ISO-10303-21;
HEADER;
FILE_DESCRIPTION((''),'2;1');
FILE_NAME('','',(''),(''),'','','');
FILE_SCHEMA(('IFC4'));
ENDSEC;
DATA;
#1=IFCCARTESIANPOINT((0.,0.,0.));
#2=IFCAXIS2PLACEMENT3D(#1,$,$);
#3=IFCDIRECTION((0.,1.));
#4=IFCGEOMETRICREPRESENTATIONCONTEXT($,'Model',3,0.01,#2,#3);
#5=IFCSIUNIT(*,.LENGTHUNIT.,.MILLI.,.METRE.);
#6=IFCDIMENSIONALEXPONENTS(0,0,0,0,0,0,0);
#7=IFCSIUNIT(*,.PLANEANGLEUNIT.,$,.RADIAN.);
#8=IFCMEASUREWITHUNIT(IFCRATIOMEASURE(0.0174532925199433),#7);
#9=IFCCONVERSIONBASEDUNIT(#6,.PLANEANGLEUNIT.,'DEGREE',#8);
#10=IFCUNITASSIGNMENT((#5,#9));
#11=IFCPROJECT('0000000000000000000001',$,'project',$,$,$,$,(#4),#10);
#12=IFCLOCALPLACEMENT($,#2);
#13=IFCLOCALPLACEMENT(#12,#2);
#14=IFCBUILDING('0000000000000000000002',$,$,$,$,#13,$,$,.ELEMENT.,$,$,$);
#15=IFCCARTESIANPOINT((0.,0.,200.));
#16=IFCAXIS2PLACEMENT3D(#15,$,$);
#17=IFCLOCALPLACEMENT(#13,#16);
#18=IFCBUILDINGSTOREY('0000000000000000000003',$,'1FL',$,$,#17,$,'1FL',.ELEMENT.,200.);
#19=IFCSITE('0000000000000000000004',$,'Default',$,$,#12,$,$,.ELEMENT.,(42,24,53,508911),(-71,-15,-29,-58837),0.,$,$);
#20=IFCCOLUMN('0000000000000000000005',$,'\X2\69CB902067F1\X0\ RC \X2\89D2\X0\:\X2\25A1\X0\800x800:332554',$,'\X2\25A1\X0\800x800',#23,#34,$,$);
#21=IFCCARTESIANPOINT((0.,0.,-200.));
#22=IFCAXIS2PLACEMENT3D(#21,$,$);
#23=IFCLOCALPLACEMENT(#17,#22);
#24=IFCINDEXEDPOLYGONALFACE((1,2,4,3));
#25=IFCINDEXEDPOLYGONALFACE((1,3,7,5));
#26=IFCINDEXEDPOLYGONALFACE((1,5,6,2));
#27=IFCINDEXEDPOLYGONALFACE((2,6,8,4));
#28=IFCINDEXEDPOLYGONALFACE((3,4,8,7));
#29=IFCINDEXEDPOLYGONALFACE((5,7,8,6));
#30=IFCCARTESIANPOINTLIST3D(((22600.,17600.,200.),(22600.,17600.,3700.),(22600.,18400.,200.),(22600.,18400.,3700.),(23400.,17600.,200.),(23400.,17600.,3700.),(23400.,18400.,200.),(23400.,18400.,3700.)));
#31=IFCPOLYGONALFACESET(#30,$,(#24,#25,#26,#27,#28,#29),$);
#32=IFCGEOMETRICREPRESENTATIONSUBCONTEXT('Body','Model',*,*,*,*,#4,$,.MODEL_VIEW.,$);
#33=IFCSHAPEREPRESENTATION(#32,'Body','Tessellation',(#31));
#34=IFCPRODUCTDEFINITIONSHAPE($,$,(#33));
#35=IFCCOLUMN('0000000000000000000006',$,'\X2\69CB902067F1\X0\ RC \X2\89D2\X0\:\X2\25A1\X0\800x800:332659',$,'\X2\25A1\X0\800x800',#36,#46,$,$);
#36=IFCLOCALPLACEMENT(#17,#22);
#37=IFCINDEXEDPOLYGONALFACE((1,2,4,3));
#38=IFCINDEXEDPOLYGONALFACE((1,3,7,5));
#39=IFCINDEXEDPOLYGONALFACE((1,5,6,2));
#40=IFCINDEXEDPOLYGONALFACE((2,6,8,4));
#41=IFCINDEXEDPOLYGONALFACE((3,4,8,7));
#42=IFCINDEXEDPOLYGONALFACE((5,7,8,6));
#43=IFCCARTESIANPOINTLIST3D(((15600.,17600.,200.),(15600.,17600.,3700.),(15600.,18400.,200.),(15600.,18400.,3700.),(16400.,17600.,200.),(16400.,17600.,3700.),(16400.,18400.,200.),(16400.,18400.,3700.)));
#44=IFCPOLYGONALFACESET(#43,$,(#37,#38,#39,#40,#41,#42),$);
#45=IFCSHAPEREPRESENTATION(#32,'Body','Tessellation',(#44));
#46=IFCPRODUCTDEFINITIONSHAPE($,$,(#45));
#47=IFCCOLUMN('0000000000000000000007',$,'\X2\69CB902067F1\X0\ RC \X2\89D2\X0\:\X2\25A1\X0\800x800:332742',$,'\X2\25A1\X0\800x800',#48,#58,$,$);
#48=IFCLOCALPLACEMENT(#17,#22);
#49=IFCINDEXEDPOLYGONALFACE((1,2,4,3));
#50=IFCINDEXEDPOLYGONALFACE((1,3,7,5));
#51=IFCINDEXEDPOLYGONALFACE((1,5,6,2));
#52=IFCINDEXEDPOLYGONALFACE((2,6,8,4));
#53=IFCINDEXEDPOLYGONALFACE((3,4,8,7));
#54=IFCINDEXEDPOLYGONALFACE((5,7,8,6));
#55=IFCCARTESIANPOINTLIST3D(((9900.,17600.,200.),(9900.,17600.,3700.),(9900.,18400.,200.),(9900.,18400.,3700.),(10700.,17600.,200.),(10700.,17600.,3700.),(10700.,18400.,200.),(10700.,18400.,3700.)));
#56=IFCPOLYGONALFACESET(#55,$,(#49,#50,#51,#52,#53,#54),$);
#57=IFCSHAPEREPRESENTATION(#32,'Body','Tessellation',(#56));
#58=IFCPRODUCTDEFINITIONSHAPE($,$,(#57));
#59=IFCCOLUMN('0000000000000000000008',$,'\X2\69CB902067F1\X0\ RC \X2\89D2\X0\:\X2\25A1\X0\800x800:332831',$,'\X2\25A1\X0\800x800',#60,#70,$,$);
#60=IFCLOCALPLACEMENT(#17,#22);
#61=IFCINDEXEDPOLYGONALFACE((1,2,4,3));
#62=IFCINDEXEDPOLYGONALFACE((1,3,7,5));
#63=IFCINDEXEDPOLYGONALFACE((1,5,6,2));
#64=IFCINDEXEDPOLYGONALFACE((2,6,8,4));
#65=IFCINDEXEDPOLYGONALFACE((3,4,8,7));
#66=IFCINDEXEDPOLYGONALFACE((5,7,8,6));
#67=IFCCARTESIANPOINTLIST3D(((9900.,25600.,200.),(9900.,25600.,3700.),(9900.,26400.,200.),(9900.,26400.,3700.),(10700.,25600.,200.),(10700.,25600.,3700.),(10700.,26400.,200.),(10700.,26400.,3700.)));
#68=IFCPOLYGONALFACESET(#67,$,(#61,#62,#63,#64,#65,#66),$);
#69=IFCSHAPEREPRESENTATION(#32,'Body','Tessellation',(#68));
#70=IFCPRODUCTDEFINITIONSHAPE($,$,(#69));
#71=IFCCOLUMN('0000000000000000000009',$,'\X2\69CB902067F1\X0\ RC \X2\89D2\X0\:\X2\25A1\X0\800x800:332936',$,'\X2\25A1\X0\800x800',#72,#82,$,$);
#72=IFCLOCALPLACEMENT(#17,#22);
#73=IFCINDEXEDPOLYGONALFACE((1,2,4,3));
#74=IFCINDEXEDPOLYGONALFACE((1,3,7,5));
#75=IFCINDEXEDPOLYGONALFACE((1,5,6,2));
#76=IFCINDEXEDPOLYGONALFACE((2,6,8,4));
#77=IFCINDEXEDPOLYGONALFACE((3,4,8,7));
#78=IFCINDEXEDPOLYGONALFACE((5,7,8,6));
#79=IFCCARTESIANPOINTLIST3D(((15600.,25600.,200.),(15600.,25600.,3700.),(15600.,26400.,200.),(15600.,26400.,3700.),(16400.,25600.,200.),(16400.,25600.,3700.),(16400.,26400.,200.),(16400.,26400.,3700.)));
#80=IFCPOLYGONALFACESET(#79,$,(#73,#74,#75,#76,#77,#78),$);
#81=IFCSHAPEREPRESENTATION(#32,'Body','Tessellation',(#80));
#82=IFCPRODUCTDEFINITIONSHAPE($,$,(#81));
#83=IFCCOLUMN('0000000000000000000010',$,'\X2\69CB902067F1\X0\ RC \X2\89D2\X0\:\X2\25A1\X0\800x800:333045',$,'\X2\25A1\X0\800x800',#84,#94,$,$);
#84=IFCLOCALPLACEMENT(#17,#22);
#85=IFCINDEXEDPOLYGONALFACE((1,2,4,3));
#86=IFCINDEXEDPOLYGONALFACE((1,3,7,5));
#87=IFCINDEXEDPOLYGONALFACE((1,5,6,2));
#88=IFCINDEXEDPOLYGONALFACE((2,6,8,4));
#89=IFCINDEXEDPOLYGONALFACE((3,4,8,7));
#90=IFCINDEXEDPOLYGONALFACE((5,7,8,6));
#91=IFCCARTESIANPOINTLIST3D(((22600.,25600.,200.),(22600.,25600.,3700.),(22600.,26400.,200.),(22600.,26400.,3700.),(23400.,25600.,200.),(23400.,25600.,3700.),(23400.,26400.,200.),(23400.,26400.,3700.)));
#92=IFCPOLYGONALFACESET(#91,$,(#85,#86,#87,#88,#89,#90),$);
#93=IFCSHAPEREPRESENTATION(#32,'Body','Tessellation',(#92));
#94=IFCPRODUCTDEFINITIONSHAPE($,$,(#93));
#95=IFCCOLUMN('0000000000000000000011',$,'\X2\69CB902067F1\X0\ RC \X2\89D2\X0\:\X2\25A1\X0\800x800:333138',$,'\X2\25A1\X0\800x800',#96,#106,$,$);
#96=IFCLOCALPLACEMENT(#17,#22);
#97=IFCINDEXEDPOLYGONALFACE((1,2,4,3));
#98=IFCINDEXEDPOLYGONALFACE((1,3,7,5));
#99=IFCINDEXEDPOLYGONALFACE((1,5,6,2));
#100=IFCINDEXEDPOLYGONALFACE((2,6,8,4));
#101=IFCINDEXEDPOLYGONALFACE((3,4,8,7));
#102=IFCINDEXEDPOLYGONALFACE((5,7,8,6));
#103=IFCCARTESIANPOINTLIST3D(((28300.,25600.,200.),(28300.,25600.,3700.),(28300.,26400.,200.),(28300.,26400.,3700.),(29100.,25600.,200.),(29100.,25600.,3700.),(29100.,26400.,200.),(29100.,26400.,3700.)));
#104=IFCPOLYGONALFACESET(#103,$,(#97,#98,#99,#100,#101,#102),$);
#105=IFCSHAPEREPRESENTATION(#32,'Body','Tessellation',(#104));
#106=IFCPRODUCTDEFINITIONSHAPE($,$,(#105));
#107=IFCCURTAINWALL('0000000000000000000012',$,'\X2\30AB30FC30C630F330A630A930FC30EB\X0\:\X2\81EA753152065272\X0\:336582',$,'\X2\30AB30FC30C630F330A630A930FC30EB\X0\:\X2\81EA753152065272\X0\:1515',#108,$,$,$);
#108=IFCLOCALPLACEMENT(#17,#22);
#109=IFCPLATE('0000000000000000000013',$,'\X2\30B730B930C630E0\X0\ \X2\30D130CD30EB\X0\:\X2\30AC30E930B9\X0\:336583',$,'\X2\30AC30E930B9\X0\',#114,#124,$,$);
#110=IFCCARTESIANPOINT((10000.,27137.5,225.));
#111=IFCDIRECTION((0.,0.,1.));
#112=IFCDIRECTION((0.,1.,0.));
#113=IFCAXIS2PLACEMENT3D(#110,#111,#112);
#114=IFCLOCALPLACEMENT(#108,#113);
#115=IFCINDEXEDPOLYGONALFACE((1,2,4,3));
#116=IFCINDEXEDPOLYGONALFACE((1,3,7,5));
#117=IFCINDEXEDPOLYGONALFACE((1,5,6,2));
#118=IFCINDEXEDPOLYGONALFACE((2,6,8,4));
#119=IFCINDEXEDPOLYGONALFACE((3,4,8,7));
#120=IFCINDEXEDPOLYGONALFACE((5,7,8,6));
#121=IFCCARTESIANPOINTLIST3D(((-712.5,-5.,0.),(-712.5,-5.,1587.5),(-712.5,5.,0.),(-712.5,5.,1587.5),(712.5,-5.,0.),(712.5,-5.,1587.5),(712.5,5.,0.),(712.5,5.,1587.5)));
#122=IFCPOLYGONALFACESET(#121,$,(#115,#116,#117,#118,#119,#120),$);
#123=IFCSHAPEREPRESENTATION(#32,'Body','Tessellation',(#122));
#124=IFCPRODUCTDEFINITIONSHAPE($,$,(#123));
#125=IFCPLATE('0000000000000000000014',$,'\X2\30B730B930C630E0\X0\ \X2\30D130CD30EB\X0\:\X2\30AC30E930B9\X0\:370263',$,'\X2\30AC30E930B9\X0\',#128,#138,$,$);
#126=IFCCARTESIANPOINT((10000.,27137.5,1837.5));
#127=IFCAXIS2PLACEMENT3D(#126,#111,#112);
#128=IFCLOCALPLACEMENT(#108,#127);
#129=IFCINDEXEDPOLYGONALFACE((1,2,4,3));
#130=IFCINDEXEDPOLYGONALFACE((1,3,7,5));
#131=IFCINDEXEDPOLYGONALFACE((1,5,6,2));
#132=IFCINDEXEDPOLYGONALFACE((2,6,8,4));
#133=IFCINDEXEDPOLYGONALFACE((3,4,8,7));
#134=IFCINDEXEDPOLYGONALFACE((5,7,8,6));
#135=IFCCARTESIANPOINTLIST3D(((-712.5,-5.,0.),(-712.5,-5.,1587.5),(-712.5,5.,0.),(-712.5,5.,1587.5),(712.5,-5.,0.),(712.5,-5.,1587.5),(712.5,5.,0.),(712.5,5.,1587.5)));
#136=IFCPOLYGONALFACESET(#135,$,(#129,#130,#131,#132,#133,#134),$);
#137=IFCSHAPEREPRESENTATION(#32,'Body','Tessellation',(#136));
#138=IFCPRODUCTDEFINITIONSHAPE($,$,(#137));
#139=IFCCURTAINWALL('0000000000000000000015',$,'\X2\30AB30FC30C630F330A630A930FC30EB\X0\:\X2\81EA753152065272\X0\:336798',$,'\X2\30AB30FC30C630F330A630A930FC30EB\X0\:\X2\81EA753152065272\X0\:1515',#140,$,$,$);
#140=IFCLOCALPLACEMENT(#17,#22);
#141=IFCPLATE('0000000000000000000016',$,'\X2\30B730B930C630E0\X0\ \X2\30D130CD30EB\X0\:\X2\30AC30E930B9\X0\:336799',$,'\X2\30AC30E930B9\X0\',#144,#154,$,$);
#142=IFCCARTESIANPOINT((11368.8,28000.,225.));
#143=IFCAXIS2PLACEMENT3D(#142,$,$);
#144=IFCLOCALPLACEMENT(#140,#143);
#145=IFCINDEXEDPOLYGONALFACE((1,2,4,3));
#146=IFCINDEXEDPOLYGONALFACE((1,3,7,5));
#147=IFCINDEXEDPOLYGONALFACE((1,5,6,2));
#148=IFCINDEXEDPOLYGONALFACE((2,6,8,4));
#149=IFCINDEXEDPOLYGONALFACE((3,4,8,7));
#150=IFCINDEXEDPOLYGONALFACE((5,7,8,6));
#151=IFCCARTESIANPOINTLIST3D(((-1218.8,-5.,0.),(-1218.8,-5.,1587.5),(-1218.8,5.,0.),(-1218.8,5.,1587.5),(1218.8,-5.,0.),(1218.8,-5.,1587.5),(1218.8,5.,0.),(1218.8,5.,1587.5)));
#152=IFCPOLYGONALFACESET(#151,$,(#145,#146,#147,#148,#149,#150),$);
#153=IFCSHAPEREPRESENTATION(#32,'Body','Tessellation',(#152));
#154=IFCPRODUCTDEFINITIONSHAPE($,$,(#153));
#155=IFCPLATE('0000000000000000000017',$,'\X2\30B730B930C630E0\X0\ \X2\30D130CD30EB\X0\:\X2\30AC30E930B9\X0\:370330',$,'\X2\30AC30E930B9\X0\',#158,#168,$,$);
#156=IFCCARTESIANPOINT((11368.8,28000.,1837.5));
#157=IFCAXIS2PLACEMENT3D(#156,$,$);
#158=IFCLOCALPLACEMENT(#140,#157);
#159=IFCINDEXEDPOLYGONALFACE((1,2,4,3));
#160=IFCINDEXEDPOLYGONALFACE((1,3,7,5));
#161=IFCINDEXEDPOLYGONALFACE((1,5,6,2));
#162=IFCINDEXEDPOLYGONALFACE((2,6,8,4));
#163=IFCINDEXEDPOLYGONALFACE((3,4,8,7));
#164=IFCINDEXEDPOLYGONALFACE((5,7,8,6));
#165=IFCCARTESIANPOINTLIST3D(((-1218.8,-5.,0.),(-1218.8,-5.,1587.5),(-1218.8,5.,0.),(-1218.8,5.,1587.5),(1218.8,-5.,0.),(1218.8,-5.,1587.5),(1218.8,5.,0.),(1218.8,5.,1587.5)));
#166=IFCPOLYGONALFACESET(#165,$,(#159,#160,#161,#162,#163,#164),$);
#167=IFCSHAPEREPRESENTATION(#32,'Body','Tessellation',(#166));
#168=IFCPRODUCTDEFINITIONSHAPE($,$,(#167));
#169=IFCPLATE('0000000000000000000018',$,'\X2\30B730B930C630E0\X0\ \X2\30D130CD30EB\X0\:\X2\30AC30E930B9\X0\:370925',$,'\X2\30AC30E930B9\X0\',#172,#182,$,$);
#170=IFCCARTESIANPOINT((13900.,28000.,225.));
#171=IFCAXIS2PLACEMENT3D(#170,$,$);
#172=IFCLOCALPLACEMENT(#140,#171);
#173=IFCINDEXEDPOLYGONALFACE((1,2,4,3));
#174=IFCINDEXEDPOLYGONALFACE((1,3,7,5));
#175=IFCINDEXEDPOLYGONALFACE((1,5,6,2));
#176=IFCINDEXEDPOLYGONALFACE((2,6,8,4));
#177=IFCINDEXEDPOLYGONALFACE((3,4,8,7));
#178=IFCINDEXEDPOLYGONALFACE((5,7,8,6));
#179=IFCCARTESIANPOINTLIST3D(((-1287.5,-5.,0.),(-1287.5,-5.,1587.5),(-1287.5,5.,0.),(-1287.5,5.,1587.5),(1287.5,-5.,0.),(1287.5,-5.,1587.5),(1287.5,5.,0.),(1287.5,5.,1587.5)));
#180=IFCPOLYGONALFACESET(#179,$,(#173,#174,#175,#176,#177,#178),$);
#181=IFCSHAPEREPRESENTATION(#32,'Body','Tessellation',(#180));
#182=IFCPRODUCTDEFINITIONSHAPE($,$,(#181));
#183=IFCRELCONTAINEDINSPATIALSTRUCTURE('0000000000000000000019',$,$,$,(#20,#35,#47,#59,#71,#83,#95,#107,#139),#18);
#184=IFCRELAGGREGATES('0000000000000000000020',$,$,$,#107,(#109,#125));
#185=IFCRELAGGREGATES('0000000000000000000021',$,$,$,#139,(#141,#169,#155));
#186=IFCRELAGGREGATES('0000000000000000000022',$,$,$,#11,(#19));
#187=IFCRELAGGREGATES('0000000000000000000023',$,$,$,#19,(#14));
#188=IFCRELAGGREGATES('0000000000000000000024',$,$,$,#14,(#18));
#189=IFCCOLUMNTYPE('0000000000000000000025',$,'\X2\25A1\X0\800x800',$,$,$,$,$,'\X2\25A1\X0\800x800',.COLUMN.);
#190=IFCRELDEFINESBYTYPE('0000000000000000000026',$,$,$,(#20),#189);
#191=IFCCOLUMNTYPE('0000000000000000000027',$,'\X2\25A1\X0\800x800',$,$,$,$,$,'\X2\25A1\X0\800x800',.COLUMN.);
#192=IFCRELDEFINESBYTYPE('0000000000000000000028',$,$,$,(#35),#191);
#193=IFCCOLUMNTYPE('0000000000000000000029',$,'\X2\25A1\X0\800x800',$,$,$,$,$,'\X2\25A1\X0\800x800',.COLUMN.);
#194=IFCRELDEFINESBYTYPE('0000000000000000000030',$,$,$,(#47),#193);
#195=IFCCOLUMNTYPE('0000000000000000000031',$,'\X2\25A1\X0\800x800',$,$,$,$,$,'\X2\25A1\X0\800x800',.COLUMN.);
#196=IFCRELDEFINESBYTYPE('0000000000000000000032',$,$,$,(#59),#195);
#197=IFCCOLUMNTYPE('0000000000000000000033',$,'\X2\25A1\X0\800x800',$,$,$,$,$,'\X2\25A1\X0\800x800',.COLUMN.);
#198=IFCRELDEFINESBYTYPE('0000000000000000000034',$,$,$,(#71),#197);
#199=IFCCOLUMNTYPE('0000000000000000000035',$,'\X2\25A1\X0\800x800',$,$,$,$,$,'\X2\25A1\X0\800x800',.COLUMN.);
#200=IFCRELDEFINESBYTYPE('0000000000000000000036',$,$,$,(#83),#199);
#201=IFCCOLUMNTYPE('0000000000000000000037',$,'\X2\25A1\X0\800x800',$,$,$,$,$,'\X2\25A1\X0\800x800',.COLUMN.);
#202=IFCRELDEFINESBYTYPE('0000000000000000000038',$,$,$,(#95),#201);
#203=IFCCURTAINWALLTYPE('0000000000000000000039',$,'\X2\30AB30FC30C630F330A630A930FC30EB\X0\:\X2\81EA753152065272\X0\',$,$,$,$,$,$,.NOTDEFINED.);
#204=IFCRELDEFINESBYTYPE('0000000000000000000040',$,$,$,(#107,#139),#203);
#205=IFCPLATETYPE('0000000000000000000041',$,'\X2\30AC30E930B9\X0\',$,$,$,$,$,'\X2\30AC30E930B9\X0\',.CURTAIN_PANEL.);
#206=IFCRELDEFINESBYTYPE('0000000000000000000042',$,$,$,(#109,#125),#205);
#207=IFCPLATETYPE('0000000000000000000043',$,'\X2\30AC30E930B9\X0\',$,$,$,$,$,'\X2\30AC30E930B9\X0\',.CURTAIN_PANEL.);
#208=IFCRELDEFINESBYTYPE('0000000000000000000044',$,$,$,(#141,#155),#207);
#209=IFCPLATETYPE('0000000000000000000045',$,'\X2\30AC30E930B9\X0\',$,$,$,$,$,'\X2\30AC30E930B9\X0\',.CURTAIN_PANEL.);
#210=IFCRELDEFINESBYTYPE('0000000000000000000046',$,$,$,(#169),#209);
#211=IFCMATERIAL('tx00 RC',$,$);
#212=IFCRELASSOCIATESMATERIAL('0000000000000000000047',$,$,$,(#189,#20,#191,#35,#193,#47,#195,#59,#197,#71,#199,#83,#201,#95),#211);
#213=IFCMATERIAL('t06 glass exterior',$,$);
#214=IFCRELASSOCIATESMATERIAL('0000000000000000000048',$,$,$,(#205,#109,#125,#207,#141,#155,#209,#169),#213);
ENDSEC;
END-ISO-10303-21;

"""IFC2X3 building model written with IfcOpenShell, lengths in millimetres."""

from ifc_helpers import new_model, entity, si_unit, converted_unit, direction, frame, frame_2d, origin, origin_2d_with_axis, place, context, subcontext, project, spatial, rectangle, extrude, source, transform, mapped, material, type_object, type_shapes, element, aggregate, save


model = new_model("IFC2X3")

# Units and contexts
model_context = context("Model", 3, precision=0.01, world=origin(), true_north=direction((0.0, 1.0)))
body_context = subcontext(model_context, "Body", "Model", "MODEL_VIEW")
ifc_project = project(units=[si_unit("LENGTHUNIT", "METRE", prefix="MILLI"), converted_unit("PLANEANGLEUNIT", "DEGREE", entity("IfcRatioMeasure", 0.0174532925199433), si_unit("PLANEANGLEUNIT", "RADIAN"), dimensions=[0, 0, 0, 0, 0, 0, 0])], contexts=[model_context])

# Site, building, storey
site_placement = place(None, origin())
site = spatial("IfcSite", under=ifc_project, at=site_placement, Name="Default", CompositionType="ELEMENT", RefLatitude=(42, 24, 53, 508911), RefLongitude=(-71, -15, -29, -58837), RefElevation=0.0)
building_placement = place(site_placement, origin())
building = spatial("IfcBuilding", under=site, at=building_placement, CompositionType="ELEMENT")
storey_placement = place(building_placement, frame((0.0, 0.0, 200.0)))
storey = spatial("IfcBuildingStorey", under=building, at=storey_placement, Name="1FL", LongName="1FL", CompositionType="ELEMENT", Elevation=200.0)

# Columns
ifc_material_1 = material(Name="tx00 RC")
column_type_1 = type_object("IfcColumnType", Name="□800x800", ElementType="□800x800", PredefinedType="COLUMN", material=ifc_material_1)
shared_shape_1 = source(origin(), body_context, "Body", "SweptSolid", [
    extrude(rectangle(XDim=800.0, YDim=800.0, at=origin_2d_with_axis()), frame((23000.0, 18000.0, 200.0), z_axis=(0.0, 0.0, 1.0), x_axis=(0.0, -1.0, 0.0)), (0.0, 0.0, 1.0), 3500.0),
])
type_shapes(column_type_1, [shared_shape_1])
column_1_placement = place(storey_placement, frame((0.0, 0.0, -200.0)))
element("IfcColumn", 1, at=column_1_placement, inside=storey, type_object=column_type_1, material=ifc_material_1, Name="構造柱 RC 角:□800x800:332554", ObjectType="□800x800", context=body_context, shape_type="MappedRepresentation", body=[
    mapped(shared_shape_1, transform((0.0, 0.0, 0.0), scale=1.0)),
])
column_type_2 = type_object("IfcColumnType", Name="□800x800", ElementType="□800x800", PredefinedType="COLUMN", material=ifc_material_1)
shared_shape_2 = source(origin(), body_context, "Body", "SweptSolid", [
    extrude(rectangle(XDim=800.0, YDim=800.0, at=frame_2d((0.0, 0.0), x_axis=(1.0, 0.0))), frame((16000.0, 18000.0, 200.0), z_axis=(0.0, 0.0, 1.0), x_axis=(0.0, -1.0, 0.0)), (0.0, 0.0, 1.0), 3500.0),
])
type_shapes(column_type_2, [shared_shape_2])
column_2_placement = place(storey_placement, frame((0.0, 0.0, -200.0)))
element("IfcColumn", 2, at=column_2_placement, inside=storey, type_object=column_type_2, material=ifc_material_1, Name="構造柱 RC 角:□800x800:332659", ObjectType="□800x800", context=body_context, shape_type="MappedRepresentation", body=[
    mapped(shared_shape_2, transform((0.0, 0.0, 0.0), scale=1.0)),
])
column_type_3 = type_object("IfcColumnType", Name="□800x800", ElementType="□800x800", PredefinedType="COLUMN", material=ifc_material_1)
shared_shape_3 = source(origin(), body_context, "Body", "SweptSolid", [
    extrude(rectangle(XDim=800.0, YDim=800.0, at=frame_2d((0.0, 0.0), x_axis=(1.0, 0.0))), frame((10300.0, 18000.0, 200.0), z_axis=(0.0, 0.0, 1.0), x_axis=(0.0, -1.0, 0.0)), (0.0, 0.0, 1.0), 3500.0),
])
type_shapes(column_type_3, [shared_shape_3])
column_3_placement = place(storey_placement, frame((0.0, 0.0, -200.0)))
element("IfcColumn", 3, at=column_3_placement, inside=storey, type_object=column_type_3, material=ifc_material_1, Name="構造柱 RC 角:□800x800:332742", ObjectType="□800x800", context=body_context, shape_type="MappedRepresentation", body=[
    mapped(shared_shape_3, transform((0.0, 0.0, 0.0), scale=1.0)),
])
column_type_4 = type_object("IfcColumnType", Name="□800x800", ElementType="□800x800", PredefinedType="COLUMN", material=ifc_material_1)
shared_shape_4 = source(origin(), body_context, "Body", "SweptSolid", [
    extrude(rectangle(XDim=800.0, YDim=800.0, at=frame_2d((0.0, 0.0), x_axis=(1.0, 0.0))), frame((10300.0, 26000.0, 200.0), z_axis=(0.0, 0.0, 1.0), x_axis=(0.0, -1.0, 0.0)), (0.0, 0.0, 1.0), 3500.0),
])
type_shapes(column_type_4, [shared_shape_4])
column_4_placement = place(storey_placement, frame((0.0, 0.0, -200.0)))
element("IfcColumn", 4, at=column_4_placement, inside=storey, type_object=column_type_4, material=ifc_material_1, Name="構造柱 RC 角:□800x800:332831", ObjectType="□800x800", context=body_context, shape_type="MappedRepresentation", body=[
    mapped(shared_shape_4, transform((0.0, 0.0, 0.0), scale=1.0)),
])
column_type_5 = type_object("IfcColumnType", Name="□800x800", ElementType="□800x800", PredefinedType="COLUMN", material=ifc_material_1)
shared_shape_5 = source(origin(), body_context, "Body", "SweptSolid", [
    extrude(rectangle(XDim=800.0, YDim=800.0, at=frame_2d((0.0, 0.0), x_axis=(1.0, 0.0))), frame((16000.0, 26000.0, 200.0), z_axis=(0.0, 0.0, 1.0), x_axis=(0.0, -1.0, 0.0)), (0.0, 0.0, 1.0), 3500.0),
])
type_shapes(column_type_5, [shared_shape_5])
column_5_placement = place(storey_placement, frame((0.0, 0.0, -200.0)))
element("IfcColumn", 5, at=column_5_placement, inside=storey, type_object=column_type_5, material=ifc_material_1, Name="構造柱 RC 角:□800x800:332936", ObjectType="□800x800", context=body_context, shape_type="MappedRepresentation", body=[
    mapped(shared_shape_5, transform((0.0, 0.0, 0.0), scale=1.0)),
])
column_type_6 = type_object("IfcColumnType", Name="□800x800", ElementType="□800x800", PredefinedType="COLUMN", material=ifc_material_1)
shared_shape_6 = source(origin(), body_context, "Body", "SweptSolid", [
    extrude(rectangle(XDim=800.0, YDim=800.0, at=origin_2d_with_axis()), frame((23000.0, 26000.0, 200.0), z_axis=(0.0, 0.0, 1.0), x_axis=(0.0, -1.0, 0.0)), (0.0, 0.0, 1.0), 3500.0),
])
type_shapes(column_type_6, [shared_shape_6])
column_6_placement = place(storey_placement, frame((0.0, 0.0, -200.0)))
element("IfcColumn", 6, at=column_6_placement, inside=storey, type_object=column_type_6, material=ifc_material_1, Name="構造柱 RC 角:□800x800:333045", ObjectType="□800x800", context=body_context, shape_type="MappedRepresentation", body=[
    mapped(shared_shape_6, transform((0.0, 0.0, 0.0), scale=1.0)),
])
column_type_7 = type_object("IfcColumnType", Name="□800x800", ElementType="□800x800", PredefinedType="COLUMN", material=ifc_material_1)
shared_shape_7 = source(origin(), body_context, "Body", "SweptSolid", [
    extrude(rectangle(XDim=800.0, YDim=800.0, at=origin_2d_with_axis()), frame((28700.0, 26000.0, 200.0), z_axis=(0.0, 0.0, 1.0), x_axis=(0.0, -1.0, 0.0)), (0.0, 0.0, 1.0), 3500.0),
])
type_shapes(column_type_7, [shared_shape_7])
column_7_placement = place(storey_placement, frame((0.0, 0.0, -200.0)))
element("IfcColumn", 7, at=column_7_placement, inside=storey, type_object=column_type_7, material=ifc_material_1, Name="構造柱 RC 角:□800x800:333138", ObjectType="□800x800", context=body_context, shape_type="MappedRepresentation", body=[
    mapped(shared_shape_7, transform((0.0, 0.0, 0.0), scale=1.0)),
])

# Curtain walls, plates
curtain_wall_type = type_object("IfcCurtainWallType", Name="カーテンウォール:自由分割", PredefinedType="NOTDEFINED")
curtain_wall_1_placement = place(storey_placement, frame((0.0, 0.0, -200.0)))
curtain_wall_1 = element("IfcCurtainWall", 8, at=curtain_wall_1_placement, inside=storey, type_object=curtain_wall_type, Name="カーテンウォール:自由分割:336582", ObjectType="カーテンウォール:自由分割:1515")
ifc_material_2 = material(Name="t06 glass exterior")
plate_type_1 = type_object("IfcPlateType", Name="ガラス", ElementType="ガラス", PredefinedType="CURTAIN_PANEL", material=ifc_material_2)
shared_shape_8 = source(origin(), body_context, "Body", "SweptSolid", [
    extrude(rectangle(XDim=10.0, YDim=1425.0, at=origin_2d_with_axis()), frame((0.0, 0.0, 0.0), z_axis=(0.0, 0.0, 1.0), x_axis=(0.0, 1.0, 0.0)), (0.0, 0.0, 1.0), 1587.5),
])
type_shapes(plate_type_1, [shared_shape_8])
plate_1_placement = place(curtain_wall_1_placement, frame((10000.0, 27137.5, 225.0), z_axis=(0.0, 0.0, 1.0), x_axis=(0.0, 1.0, 0.0)))
plate_1 = element("IfcPlate", 9, at=plate_1_placement, type_object=plate_type_1, material=ifc_material_2, Name="システム パネル:ガラス:336583", ObjectType="ガラス", context=body_context, shape_type="MappedRepresentation", body=[
    mapped(shared_shape_8, transform((0.0, 0.0, 0.0), scale=1.0)),
])
plate_2_placement = place(curtain_wall_1_placement, frame((10000.0, 27137.5, 1837.5), z_axis=(0.0, 0.0, 1.0), x_axis=(0.0, 1.0, 0.0)))
plate_2 = element("IfcPlate", 10, at=plate_2_placement, type_object=plate_type_1, material=ifc_material_2, Name="システム パネル:ガラス:370263", ObjectType="ガラス", context=body_context, shape_type="MappedRepresentation", body=[
    mapped(shared_shape_8, transform((0.0, 0.0, 0.0), scale=1.0)),
])
aggregate(curtain_wall_1, [plate_1, plate_2])
curtain_wall_2_placement = place(storey_placement, frame((0.0, 0.0, -200.0)))
curtain_wall_2 = element("IfcCurtainWall", 11, at=curtain_wall_2_placement, inside=storey, type_object=curtain_wall_type, Name="カーテンウォール:自由分割:336798", ObjectType="カーテンウォール:自由分割:1515")
plate_type_2 = type_object("IfcPlateType", Name="ガラス", ElementType="ガラス", PredefinedType="CURTAIN_PANEL", material=ifc_material_2)
shared_shape_9 = source(origin(), body_context, "Body", "SweptSolid", [
    extrude(rectangle(XDim=10.0, YDim=2437.5, at=frame_2d((0.0, 0.0), x_axis=(1.0, 0.0))), frame((0.0, 0.0, 0.0), z_axis=(0.0, 0.0, 1.0), x_axis=(0.0, 1.0, 0.0)), (0.0, 0.0, 1.0), 1587.5),
])
type_shapes(plate_type_2, [shared_shape_9])
plate_3_placement = place(curtain_wall_2_placement, frame((11368.8, 28000.0, 225.0)))
plate_3 = element("IfcPlate", 12, at=plate_3_placement, type_object=plate_type_2, material=ifc_material_2, Name="システム パネル:ガラス:336799", ObjectType="ガラス", context=body_context, shape_type="MappedRepresentation", body=[
    mapped(shared_shape_9, transform((0.0, 0.0, 0.0), scale=1.0)),
])
plate_4_placement = place(curtain_wall_2_placement, frame((11368.8, 28000.0, 1837.5)))
plate_4 = element("IfcPlate", 13, at=plate_4_placement, type_object=plate_type_2, material=ifc_material_2, Name="システム パネル:ガラス:370330", ObjectType="ガラス", context=body_context, shape_type="MappedRepresentation", body=[
    mapped(shared_shape_9, transform((0.0, 0.0, 0.0), scale=1.0)),
])
plate_type_3 = type_object("IfcPlateType", Name="ガラス", ElementType="ガラス", PredefinedType="CURTAIN_PANEL", material=ifc_material_2)
shared_shape_10 = source(origin(), body_context, "Body", "SweptSolid", [
    extrude(rectangle(XDim=10.0, YDim=2575.0, at=origin_2d_with_axis()), frame((0.0, 0.0, 0.0), z_axis=(0.0, 0.0, 1.0), x_axis=(0.0, 1.0, 0.0)), (0.0, 0.0, 1.0), 1587.5),
])
type_shapes(plate_type_3, [shared_shape_10])
plate_5_placement = place(curtain_wall_2_placement, frame((13900.0, 28000.0, 225.0)))
plate_5 = element("IfcPlate", 14, at=plate_5_placement, type_object=plate_type_3, material=ifc_material_2, Name="システム パネル:ガラス:370925", ObjectType="ガラス", context=body_context, shape_type="MappedRepresentation", body=[
    mapped(shared_shape_10, transform((0.0, 0.0, 0.0), scale=1.0)),
])
aggregate(curtain_wall_2, [plate_3, plate_5, plate_4])

save(model, "model.ifc")
